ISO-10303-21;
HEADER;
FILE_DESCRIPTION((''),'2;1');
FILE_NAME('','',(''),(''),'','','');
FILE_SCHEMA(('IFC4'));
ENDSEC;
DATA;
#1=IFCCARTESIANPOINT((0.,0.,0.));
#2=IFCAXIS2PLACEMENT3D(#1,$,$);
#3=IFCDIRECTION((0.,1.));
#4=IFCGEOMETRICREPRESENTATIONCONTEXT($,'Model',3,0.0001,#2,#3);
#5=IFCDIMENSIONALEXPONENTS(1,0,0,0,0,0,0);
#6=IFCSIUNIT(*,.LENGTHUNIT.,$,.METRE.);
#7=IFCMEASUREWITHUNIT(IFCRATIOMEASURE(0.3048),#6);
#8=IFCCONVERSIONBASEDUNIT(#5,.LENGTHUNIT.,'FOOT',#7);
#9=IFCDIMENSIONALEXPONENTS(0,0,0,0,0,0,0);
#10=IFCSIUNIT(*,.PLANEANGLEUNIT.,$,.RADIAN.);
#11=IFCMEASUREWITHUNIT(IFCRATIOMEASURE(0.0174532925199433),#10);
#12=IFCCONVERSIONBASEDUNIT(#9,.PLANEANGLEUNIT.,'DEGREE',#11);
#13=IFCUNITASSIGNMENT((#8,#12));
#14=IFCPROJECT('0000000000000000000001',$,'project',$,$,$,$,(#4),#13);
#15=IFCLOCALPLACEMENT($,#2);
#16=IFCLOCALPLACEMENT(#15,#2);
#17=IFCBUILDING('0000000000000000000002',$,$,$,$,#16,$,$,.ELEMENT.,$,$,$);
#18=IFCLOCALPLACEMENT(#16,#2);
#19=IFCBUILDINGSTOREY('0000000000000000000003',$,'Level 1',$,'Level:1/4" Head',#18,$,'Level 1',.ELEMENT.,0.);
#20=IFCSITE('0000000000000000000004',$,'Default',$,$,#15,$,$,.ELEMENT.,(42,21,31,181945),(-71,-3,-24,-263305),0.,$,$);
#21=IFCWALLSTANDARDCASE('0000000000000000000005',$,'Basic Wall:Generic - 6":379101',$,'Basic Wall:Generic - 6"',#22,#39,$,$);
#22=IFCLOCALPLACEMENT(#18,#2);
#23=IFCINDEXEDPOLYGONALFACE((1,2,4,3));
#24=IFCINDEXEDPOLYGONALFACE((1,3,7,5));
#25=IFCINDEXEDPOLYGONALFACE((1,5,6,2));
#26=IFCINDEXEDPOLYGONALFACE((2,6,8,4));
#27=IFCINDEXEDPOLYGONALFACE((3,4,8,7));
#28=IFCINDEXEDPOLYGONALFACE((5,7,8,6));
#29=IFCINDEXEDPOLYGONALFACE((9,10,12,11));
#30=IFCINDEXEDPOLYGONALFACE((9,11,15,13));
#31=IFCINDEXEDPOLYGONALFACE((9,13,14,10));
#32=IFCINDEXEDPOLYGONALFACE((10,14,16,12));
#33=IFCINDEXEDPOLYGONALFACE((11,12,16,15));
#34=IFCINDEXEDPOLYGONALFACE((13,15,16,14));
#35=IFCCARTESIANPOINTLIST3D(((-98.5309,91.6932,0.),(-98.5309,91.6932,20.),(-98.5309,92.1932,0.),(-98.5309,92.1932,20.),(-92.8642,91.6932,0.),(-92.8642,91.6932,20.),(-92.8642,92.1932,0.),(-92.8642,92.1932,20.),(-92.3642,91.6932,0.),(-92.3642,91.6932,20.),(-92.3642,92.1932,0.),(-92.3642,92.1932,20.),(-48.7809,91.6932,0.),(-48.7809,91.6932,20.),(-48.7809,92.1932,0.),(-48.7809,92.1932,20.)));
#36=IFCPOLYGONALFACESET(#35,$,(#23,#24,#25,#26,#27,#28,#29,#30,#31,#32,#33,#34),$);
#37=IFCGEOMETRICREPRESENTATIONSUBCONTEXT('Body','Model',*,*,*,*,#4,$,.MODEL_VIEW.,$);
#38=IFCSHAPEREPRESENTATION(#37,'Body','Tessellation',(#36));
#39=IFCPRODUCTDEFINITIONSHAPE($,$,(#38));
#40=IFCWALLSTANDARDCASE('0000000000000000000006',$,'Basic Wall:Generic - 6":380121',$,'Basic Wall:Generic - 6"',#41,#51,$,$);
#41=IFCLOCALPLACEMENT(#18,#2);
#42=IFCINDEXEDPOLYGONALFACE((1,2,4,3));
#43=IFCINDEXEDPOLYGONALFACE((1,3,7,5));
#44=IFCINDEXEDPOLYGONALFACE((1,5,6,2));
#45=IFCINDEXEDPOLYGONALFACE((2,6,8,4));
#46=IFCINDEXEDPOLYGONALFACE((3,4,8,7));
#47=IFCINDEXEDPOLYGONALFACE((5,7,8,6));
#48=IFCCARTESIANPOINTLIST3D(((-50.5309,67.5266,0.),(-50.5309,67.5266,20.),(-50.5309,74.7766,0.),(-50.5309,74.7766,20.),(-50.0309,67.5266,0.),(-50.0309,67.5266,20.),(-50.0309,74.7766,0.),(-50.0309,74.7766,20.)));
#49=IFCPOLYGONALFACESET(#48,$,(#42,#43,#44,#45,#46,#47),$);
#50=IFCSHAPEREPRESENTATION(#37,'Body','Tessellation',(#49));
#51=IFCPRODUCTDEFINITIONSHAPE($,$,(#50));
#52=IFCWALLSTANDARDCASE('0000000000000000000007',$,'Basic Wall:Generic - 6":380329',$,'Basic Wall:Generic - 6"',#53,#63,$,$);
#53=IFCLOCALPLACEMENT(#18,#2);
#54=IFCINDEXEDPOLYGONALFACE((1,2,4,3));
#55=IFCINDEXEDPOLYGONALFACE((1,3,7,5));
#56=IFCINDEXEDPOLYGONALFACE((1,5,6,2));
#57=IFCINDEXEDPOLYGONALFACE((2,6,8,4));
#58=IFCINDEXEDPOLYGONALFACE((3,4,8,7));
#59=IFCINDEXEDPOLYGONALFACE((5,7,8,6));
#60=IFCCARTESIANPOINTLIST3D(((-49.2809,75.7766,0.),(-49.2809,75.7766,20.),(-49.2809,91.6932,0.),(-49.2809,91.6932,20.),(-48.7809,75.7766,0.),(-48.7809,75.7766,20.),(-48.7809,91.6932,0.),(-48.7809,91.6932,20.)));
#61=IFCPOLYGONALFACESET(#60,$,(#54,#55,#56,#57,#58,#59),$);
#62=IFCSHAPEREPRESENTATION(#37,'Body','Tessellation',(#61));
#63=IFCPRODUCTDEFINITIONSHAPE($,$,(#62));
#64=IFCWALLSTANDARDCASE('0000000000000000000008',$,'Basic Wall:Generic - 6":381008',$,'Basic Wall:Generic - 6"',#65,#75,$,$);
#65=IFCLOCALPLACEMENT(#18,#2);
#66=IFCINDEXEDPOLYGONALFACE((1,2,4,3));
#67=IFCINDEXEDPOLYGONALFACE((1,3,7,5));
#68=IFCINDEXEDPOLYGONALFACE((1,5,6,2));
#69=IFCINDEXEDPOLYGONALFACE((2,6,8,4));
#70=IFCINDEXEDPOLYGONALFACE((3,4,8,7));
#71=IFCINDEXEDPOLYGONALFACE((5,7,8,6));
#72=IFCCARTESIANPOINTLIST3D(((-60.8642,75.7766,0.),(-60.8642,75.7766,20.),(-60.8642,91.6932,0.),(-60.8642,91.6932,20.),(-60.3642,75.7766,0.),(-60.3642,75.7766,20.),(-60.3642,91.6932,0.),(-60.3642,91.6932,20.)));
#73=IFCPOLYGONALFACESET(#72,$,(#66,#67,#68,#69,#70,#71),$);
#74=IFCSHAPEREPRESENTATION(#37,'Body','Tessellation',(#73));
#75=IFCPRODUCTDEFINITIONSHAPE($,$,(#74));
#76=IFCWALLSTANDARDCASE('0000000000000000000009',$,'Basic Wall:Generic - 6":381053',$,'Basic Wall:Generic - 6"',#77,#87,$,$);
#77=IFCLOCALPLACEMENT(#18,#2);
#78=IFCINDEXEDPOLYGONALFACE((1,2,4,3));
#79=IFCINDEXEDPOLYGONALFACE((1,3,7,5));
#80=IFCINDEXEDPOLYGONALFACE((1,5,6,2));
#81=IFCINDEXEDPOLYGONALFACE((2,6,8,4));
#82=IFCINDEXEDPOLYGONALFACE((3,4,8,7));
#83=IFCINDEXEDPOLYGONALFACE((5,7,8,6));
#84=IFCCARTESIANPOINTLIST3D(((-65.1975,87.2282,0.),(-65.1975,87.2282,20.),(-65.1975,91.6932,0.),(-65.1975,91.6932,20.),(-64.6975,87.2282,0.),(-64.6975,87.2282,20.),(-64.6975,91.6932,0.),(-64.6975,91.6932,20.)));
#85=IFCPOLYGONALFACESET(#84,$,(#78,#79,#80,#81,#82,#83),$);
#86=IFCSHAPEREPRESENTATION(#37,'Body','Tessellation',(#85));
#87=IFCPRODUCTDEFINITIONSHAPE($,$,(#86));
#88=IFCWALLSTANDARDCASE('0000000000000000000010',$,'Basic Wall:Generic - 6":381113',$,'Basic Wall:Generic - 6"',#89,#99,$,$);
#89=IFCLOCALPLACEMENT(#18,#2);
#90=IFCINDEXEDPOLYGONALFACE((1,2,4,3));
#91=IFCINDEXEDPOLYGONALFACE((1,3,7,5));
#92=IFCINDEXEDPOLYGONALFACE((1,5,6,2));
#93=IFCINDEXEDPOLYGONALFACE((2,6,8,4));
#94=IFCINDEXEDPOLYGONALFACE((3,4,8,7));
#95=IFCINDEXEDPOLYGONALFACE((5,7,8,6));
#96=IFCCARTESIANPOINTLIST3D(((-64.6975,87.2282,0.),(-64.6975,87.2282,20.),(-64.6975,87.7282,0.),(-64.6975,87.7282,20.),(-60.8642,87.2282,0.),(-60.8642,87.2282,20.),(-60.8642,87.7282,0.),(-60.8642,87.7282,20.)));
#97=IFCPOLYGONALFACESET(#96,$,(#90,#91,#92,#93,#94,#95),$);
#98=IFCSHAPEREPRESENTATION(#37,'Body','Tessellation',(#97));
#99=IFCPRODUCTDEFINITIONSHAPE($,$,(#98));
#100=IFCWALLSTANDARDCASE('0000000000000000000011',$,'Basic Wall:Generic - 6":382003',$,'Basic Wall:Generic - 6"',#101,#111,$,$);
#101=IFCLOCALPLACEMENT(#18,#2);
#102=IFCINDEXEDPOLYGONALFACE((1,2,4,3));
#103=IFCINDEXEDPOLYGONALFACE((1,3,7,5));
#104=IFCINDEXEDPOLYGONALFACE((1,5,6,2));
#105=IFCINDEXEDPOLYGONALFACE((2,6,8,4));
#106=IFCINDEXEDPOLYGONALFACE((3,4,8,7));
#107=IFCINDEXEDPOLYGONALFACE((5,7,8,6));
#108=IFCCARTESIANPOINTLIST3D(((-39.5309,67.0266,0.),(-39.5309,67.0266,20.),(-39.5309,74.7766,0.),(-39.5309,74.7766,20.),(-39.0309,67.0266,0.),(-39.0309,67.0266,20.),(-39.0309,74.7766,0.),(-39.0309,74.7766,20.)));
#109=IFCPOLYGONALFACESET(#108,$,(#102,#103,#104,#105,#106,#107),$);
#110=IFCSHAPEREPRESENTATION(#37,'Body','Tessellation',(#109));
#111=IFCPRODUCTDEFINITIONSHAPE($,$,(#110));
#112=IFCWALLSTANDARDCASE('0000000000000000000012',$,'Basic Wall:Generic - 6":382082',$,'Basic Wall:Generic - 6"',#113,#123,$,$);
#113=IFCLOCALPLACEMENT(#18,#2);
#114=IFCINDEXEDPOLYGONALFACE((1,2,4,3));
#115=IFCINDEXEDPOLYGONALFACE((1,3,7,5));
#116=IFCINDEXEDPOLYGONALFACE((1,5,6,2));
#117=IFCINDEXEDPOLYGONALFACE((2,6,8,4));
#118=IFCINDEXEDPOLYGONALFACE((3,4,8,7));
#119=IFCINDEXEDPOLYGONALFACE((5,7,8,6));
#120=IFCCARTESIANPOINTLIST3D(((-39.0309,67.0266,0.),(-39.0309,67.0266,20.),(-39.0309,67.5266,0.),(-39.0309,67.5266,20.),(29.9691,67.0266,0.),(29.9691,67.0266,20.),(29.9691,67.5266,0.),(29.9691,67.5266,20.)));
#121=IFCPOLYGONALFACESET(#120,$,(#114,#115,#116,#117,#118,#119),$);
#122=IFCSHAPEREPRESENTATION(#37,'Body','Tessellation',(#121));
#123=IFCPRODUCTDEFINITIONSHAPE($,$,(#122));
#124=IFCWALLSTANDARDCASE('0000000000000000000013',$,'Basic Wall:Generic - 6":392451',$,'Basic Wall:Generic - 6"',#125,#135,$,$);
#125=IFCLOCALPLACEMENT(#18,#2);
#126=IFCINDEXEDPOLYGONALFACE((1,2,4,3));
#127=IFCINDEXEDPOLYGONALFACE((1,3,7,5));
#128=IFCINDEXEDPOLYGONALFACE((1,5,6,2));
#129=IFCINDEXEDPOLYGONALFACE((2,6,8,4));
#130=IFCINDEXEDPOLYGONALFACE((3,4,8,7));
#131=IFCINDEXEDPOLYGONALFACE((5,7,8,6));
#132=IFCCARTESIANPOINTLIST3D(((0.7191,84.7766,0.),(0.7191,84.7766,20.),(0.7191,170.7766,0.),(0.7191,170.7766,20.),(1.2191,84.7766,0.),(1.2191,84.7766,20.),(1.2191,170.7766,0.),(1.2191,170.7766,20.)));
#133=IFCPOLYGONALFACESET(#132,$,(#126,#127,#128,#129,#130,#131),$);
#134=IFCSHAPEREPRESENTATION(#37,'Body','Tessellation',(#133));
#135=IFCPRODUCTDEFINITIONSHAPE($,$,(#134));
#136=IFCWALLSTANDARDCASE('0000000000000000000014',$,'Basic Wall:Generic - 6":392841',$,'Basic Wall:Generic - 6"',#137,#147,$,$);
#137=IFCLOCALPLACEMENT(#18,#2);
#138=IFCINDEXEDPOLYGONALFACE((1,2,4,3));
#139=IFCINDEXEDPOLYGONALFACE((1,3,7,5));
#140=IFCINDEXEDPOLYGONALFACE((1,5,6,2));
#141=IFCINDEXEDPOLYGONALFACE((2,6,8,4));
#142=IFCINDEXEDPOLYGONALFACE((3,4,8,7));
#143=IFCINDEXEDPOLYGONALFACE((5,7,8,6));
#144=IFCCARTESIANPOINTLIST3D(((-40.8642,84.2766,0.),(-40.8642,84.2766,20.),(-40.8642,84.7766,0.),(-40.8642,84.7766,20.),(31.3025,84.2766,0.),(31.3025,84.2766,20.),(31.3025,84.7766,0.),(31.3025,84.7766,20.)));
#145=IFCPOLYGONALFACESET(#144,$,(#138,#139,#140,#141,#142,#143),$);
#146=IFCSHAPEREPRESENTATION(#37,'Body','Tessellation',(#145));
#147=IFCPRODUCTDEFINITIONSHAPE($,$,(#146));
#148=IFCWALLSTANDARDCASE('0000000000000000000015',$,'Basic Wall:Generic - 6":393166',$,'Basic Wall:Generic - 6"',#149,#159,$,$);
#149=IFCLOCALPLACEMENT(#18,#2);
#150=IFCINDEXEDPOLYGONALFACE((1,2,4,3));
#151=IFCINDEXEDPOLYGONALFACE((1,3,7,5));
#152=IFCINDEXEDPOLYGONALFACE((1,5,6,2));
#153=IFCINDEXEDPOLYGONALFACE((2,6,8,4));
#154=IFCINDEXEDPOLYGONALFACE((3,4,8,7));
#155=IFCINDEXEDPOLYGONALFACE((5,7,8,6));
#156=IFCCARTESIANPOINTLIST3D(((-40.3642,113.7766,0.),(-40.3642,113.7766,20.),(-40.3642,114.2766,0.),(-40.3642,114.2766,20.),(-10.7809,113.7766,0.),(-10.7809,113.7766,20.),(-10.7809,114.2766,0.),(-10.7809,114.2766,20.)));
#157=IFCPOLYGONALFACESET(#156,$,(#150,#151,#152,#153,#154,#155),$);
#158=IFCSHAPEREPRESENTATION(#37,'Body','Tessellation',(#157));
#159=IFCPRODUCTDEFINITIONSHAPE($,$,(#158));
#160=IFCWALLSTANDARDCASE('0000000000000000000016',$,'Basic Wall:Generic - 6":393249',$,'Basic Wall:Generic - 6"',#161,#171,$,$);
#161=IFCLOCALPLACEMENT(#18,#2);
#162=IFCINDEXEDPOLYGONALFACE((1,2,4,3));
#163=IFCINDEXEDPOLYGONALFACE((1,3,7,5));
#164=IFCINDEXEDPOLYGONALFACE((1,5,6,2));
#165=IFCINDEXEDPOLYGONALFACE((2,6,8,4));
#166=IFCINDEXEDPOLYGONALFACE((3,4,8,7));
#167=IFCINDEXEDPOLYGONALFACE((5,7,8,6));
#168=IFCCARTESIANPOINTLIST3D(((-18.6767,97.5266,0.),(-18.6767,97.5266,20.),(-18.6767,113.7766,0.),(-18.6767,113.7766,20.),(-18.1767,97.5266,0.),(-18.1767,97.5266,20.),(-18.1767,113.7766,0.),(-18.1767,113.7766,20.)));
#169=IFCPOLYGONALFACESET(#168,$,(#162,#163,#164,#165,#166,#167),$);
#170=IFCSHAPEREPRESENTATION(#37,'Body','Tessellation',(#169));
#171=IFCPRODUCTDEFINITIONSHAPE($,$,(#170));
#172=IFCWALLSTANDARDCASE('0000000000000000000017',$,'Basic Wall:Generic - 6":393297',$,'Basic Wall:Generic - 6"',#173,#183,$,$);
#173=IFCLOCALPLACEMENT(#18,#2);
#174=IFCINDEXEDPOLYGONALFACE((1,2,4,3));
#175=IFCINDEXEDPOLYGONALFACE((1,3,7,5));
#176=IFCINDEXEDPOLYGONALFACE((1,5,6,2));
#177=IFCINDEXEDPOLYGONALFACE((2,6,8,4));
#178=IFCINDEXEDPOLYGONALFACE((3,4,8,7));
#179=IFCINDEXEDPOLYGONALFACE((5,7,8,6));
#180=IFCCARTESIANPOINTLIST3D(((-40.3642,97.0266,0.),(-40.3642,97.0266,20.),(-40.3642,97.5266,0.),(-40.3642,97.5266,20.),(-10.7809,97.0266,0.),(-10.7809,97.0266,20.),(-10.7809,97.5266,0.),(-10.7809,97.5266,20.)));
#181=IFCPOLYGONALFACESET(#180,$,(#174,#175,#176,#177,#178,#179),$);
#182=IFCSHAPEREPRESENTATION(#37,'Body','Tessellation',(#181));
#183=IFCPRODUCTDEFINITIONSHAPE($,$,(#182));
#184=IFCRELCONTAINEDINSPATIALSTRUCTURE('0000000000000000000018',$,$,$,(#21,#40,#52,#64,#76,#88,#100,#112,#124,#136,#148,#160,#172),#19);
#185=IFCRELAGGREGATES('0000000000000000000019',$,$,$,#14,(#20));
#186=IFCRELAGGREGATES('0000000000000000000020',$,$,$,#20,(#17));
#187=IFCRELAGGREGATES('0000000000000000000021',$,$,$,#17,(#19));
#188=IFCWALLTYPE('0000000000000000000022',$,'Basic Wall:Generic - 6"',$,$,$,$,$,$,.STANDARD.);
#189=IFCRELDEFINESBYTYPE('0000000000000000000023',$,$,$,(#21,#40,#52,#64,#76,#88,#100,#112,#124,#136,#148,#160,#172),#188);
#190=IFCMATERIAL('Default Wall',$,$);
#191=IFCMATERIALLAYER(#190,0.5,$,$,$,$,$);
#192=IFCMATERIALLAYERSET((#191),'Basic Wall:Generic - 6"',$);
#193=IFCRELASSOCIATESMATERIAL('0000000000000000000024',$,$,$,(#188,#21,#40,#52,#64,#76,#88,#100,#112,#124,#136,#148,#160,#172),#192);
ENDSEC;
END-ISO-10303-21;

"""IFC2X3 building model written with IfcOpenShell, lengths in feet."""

from ifc_helpers import new_model, entity, si_unit, converted_unit, direction, frame, frame_2d, origin, origin_2d_with_axis, place, context, subcontext, project, spatial, rectangle, extrude, material, layer, layer_set, layer_usage, type_object, element, save


model = new_model("IFC2X3")

# Units and contexts
model_context = context("Model", 3, precision=0.0001, world=origin(), true_north=direction((0.0, 1.0)))
body_context = subcontext(model_context, "Body", "Model", "MODEL_VIEW")
ifc_project = project(units=[converted_unit("LENGTHUNIT", "FOOT", entity("IfcRatioMeasure", 0.3048), si_unit("LENGTHUNIT", "METRE"), dimensions=[1, 0, 0, 0, 0, 0, 0]), converted_unit("PLANEANGLEUNIT", "DEGREE", entity("IfcRatioMeasure", 0.0174532925199433), si_unit("PLANEANGLEUNIT", "RADIAN"), dimensions=[0, 0, 0, 0, 0, 0, 0])], contexts=[model_context])

# Site, building, storey
site_placement = place(None, origin())
site = spatial("IfcSite", under=ifc_project, at=site_placement, Name="Default", CompositionType="ELEMENT", RefLatitude=(42, 21, 31, 181945), RefLongitude=(-71, -3, -24, -263305), RefElevation=0.0)
building_placement = place(site_placement, origin())
building = spatial("IfcBuilding", under=site, at=building_placement, CompositionType="ELEMENT")
storey_placement = place(building_placement, origin())
storey = spatial("IfcBuildingStorey", under=building, at=storey_placement, Name="Level 1", ObjectType="Level:1/4\" Head", LongName="Level 1", CompositionType="ELEMENT", Elevation=0.0)

# Wall, opening
ifc_material = material(Name="Default Wall")
ifc_layer = layer(ifc_material, 0.5)
ifc_layer_set = layer_set([ifc_layer], Name="Basic Wall:Generic - 6\"")
ifc_layer_usage_1 = layer_usage(ifc_layer_set, "AXIS2", "NEGATIVE", 0.25)
wall_type = type_object("IfcWallType", Name="Basic Wall:Generic - 6\"", PredefinedType="STANDARD", material=ifc_layer_set)
wall_1_placement = place(storey_placement, frame((-48.7809, 91.9432, 0.0), z_axis=(0.0, 0.0, 1.0), x_axis=(-1.0, 0.0, 0.0)))
wall_1 = element("IfcWallStandardCase", 1, at=wall_1_placement, inside=storey, type_object=wall_type, material=ifc_layer_usage_1, Name="Basic Wall:Generic - 6\":379101", ObjectType="Basic Wall:Generic - 6\"", context=body_context, shape_type="SweptSolid", body=[
    extrude(rectangle(XDim=49.75, YDim=0.5, at=frame_2d((24.875, 0.0), x_axis=(-1.0, 0.0))), origin(), (0.0, 0.0, 1.0), 20.0),
])
opening_1_placement = place(storey_placement, frame((-48.7809, 91.9432, 0.0), z_axis=(0.0, 0.0, 1.0), x_axis=(-1.0, 0.0, 0.0)))
element("IfcOpeningElement", 2, at=opening_1_placement, cuts=wall_1, ObjectType="Opening", context=body_context, shape_type="SweptSolid", body=[
    extrude(rectangle(XDim=20.0, YDim=0.5, at=origin_2d_with_axis()), frame((44.0833, 0.0, 10.0), z_axis=(-1.0, 0.0, 0.0), x_axis=(0.0, 0.0, 1.0)), (0.0, 0.0, 1.0), 0.5),
])

# Walls
ifc_layer_usage_2 = layer_usage(ifc_layer_set, "AXIS2", "NEGATIVE", 0.25)
wall_2_placement = place(storey_placement, frame((-50.2809, 67.5266, 0.0), z_axis=(0.0, 0.0, 1.0), x_axis=(0.0, 1.0, 0.0)))
element("IfcWallStandardCase", 3, at=wall_2_placement, inside=storey, type_object=wall_type, material=ifc_layer_usage_2, Name="Basic Wall:Generic - 6\":380121", ObjectType="Basic Wall:Generic - 6\"", context=body_context, shape_type="SweptSolid", body=[
    extrude(rectangle(XDim=7.25, YDim=0.5, at=frame_2d((3.625, 0.0), x_axis=(-1.0, 0.0))), origin(), (0.0, 0.0, 1.0), 20.0),
])
ifc_layer_usage_3 = layer_usage(ifc_layer_set, "AXIS2", "NEGATIVE", 0.25)
wall_3_placement = place(storey_placement, frame((-49.0309, 91.6932, 0.0), z_axis=(0.0, 0.0, 1.0), x_axis=(0.0, -1.0, 0.0)))
element("IfcWallStandardCase", 4, at=wall_3_placement, inside=storey, type_object=wall_type, material=ifc_layer_usage_3, Name="Basic Wall:Generic - 6\":380329", ObjectType="Basic Wall:Generic - 6\"", context=body_context, shape_type="SweptSolid", body=[
    extrude(rectangle(XDim=15.9167, YDim=0.5, at=frame_2d((7.9583, 0.0), x_axis=(-1.0, 0.0))), origin(), (0.0, 0.0, 1.0), 20.0),
])
ifc_layer_usage_4 = layer_usage(ifc_layer_set, "AXIS2", "NEGATIVE", 0.25)
wall_4_placement = place(storey_placement, frame((-60.6142, 75.7766, 0.0), z_axis=(0.0, 0.0, 1.0), x_axis=(0.0, 1.0, 0.0)))
element("IfcWallStandardCase", 5, at=wall_4_placement, inside=storey, type_object=wall_type, material=ifc_layer_usage_4, Name="Basic Wall:Generic - 6\":381008", ObjectType="Basic Wall:Generic - 6\"", context=body_context, shape_type="SweptSolid", body=[
    extrude(rectangle(XDim=15.9167, YDim=0.5, at=frame_2d((7.9583, 0.0), x_axis=(-1.0, 0.0))), origin(), (0.0, 0.0, 1.0), 20.0),
])
ifc_layer_usage_5 = layer_usage(ifc_layer_set, "AXIS2", "NEGATIVE", 0.25)
wall_5_placement = place(storey_placement, frame((-64.9475, 91.6932, 0.0), z_axis=(0.0, 0.0, 1.0), x_axis=(0.0, -1.0, 0.0)))
element("IfcWallStandardCase", 6, at=wall_5_placement, inside=storey, type_object=wall_type, material=ifc_layer_usage_5, Name="Basic Wall:Generic - 6\":381053", ObjectType="Basic Wall:Generic - 6\"", context=body_context, shape_type="SweptSolid", body=[
    extrude(rectangle(XDim=4.4651, YDim=0.5, at=frame_2d((2.2325, 0.0), x_axis=(-1.0, 0.0))), origin(), (0.0, 0.0, 1.0), 20.0),
])
ifc_layer_usage_6 = layer_usage(ifc_layer_set, "AXIS2", "NEGATIVE", 0.25)
wall_6_placement = place(storey_placement, frame((-64.6975, 87.4782, 0.0)))
element("IfcWallStandardCase", 7, at=wall_6_placement, inside=storey, type_object=wall_type, material=ifc_layer_usage_6, Name="Basic Wall:Generic - 6\":381113", ObjectType="Basic Wall:Generic - 6\"", context=body_context, shape_type="SweptSolid", body=[
    extrude(rectangle(XDim=3.8333, YDim=0.5, at=frame_2d((1.9167, 0.0), x_axis=(-1.0, 0.0))), origin(), (0.0, 0.0, 1.0), 20.0),
])
ifc_layer_usage_7 = layer_usage(ifc_layer_set, "AXIS2", "NEGATIVE", 0.25)
wall_7_placement = place(storey_placement, frame((-39.2809, 74.7766, 0.0), z_axis=(0.0, 0.0, 1.0), x_axis=(0.0, -1.0, 0.0)))
element("IfcWallStandardCase", 8, at=wall_7_placement, inside=storey, type_object=wall_type, material=ifc_layer_usage_7, Name="Basic Wall:Generic - 6\":382003", ObjectType="Basic Wall:Generic - 6\"", context=body_context, shape_type="SweptSolid", body=[
    extrude(rectangle(XDim=7.75, YDim=0.5, at=frame_2d((3.875, 0.0), x_axis=(-1.0, 0.0))), origin(), (0.0, 0.0, 1.0), 20.0),
])
ifc_layer_usage_8 = layer_usage(ifc_layer_set, "AXIS2", "NEGATIVE", 0.25)
wall_8_placement = place(storey_placement, frame((-39.0309, 67.2766, 0.0)))
element("IfcWallStandardCase", 9, at=wall_8_placement, inside=storey, type_object=wall_type, material=ifc_layer_usage_8, Name="Basic Wall:Generic - 6\":382082", ObjectType="Basic Wall:Generic - 6\"", context=body_context, shape_type="SweptSolid", body=[
    extrude(rectangle(XDim=69.0, YDim=0.5, at=frame_2d((34.5, 0.0), x_axis=(-1.0, 0.0))), origin(), (0.0, 0.0, 1.0), 20.0),
])
ifc_layer_usage_9 = layer_usage(ifc_layer_set, "AXIS2", "NEGATIVE", 0.25)
wall_9_placement = place(storey_placement, frame((0.9691, 84.7766, 0.0), z_axis=(0.0, 0.0, 1.0), x_axis=(0.0, 1.0, 0.0)))
element("IfcWallStandardCase", 10, at=wall_9_placement, inside=storey, type_object=wall_type, material=ifc_layer_usage_9, Name="Basic Wall:Generic - 6\":392451", ObjectType="Basic Wall:Generic - 6\"", context=body_context, shape_type="SweptSolid", body=[
    extrude(rectangle(XDim=86.0, YDim=0.5, at=frame_2d((43.0, 0.0), x_axis=(-1.0, 0.0))), origin(), (0.0, 0.0, 1.0), 20.0),
])
ifc_layer_usage_10 = layer_usage(ifc_layer_set, "AXIS2", "NEGATIVE", 0.25)
wall_10_placement = place(storey_placement, frame((-40.8642, 84.5266, 0.0)))
element("IfcWallStandardCase", 11, at=wall_10_placement, inside=storey, type_object=wall_type, material=ifc_layer_usage_10, Name="Basic Wall:Generic - 6\":392841", ObjectType="Basic Wall:Generic - 6\"", context=body_context, shape_type="SweptSolid", body=[
    extrude(rectangle(XDim=72.1667, YDim=0.5, at=frame_2d((36.0833, 0.0), x_axis=(-1.0, 0.0))), origin(), (0.0, 0.0, 1.0), 20.0),
])
ifc_layer_usage_11 = layer_usage(ifc_layer_set, "AXIS2", "NEGATIVE", 0.25)
wall_11_placement = place(storey_placement, frame((-10.7809, 114.0266, 0.0), z_axis=(0.0, 0.0, 1.0), x_axis=(-1.0, 0.0, 0.0)))
element("IfcWallStandardCase", 12, at=wall_11_placement, inside=storey, type_object=wall_type, material=ifc_layer_usage_11, Name="Basic Wall:Generic - 6\":393166", ObjectType="Basic Wall:Generic - 6\"", context=body_context, shape_type="SweptSolid", body=[
    extrude(rectangle(XDim=29.5833, YDim=0.5, at=frame_2d((14.7917, 0.0), x_axis=(-1.0, 0.0))), origin(), (0.0, 0.0, 1.0), 20.0),
])
ifc_layer_usage_12 = layer_usage(ifc_layer_set, "AXIS2", "NEGATIVE", 0.25)
wall_12_placement = place(storey_placement, frame((-18.4267, 113.7766, 0.0), z_axis=(0.0, 0.0, 1.0), x_axis=(0.0, -1.0, 0.0)))
element("IfcWallStandardCase", 13, at=wall_12_placement, inside=storey, type_object=wall_type, material=ifc_layer_usage_12, Name="Basic Wall:Generic - 6\":393249", ObjectType="Basic Wall:Generic - 6\"", context=body_context, shape_type="SweptSolid", body=[
    extrude(rectangle(XDim=16.25, YDim=0.5, at=frame_2d((8.125, 0.0), x_axis=(-1.0, 0.0))), origin(), (0.0, 0.0, 1.0), 20.0),
])
ifc_layer_usage_13 = layer_usage(ifc_layer_set, "AXIS2", "NEGATIVE", 0.25)
wall_13_placement = place(storey_placement, frame((-10.7809, 97.2766, 0.0), z_axis=(0.0, 0.0, 1.0), x_axis=(-1.0, 0.0, 0.0)))
element("IfcWallStandardCase", 14, at=wall_13_placement, inside=storey, type_object=wall_type, material=ifc_layer_usage_13, Name="Basic Wall:Generic - 6\":393297", ObjectType="Basic Wall:Generic - 6\"", context=body_context, shape_type="SweptSolid", body=[
    extrude(rectangle(XDim=29.5833, YDim=0.5, at=frame_2d((14.7917, 0.0), x_axis=(-1.0, 0.0))), origin(), (0.0, 0.0, 1.0), 20.0),
])

save(model, "model.ifc")
